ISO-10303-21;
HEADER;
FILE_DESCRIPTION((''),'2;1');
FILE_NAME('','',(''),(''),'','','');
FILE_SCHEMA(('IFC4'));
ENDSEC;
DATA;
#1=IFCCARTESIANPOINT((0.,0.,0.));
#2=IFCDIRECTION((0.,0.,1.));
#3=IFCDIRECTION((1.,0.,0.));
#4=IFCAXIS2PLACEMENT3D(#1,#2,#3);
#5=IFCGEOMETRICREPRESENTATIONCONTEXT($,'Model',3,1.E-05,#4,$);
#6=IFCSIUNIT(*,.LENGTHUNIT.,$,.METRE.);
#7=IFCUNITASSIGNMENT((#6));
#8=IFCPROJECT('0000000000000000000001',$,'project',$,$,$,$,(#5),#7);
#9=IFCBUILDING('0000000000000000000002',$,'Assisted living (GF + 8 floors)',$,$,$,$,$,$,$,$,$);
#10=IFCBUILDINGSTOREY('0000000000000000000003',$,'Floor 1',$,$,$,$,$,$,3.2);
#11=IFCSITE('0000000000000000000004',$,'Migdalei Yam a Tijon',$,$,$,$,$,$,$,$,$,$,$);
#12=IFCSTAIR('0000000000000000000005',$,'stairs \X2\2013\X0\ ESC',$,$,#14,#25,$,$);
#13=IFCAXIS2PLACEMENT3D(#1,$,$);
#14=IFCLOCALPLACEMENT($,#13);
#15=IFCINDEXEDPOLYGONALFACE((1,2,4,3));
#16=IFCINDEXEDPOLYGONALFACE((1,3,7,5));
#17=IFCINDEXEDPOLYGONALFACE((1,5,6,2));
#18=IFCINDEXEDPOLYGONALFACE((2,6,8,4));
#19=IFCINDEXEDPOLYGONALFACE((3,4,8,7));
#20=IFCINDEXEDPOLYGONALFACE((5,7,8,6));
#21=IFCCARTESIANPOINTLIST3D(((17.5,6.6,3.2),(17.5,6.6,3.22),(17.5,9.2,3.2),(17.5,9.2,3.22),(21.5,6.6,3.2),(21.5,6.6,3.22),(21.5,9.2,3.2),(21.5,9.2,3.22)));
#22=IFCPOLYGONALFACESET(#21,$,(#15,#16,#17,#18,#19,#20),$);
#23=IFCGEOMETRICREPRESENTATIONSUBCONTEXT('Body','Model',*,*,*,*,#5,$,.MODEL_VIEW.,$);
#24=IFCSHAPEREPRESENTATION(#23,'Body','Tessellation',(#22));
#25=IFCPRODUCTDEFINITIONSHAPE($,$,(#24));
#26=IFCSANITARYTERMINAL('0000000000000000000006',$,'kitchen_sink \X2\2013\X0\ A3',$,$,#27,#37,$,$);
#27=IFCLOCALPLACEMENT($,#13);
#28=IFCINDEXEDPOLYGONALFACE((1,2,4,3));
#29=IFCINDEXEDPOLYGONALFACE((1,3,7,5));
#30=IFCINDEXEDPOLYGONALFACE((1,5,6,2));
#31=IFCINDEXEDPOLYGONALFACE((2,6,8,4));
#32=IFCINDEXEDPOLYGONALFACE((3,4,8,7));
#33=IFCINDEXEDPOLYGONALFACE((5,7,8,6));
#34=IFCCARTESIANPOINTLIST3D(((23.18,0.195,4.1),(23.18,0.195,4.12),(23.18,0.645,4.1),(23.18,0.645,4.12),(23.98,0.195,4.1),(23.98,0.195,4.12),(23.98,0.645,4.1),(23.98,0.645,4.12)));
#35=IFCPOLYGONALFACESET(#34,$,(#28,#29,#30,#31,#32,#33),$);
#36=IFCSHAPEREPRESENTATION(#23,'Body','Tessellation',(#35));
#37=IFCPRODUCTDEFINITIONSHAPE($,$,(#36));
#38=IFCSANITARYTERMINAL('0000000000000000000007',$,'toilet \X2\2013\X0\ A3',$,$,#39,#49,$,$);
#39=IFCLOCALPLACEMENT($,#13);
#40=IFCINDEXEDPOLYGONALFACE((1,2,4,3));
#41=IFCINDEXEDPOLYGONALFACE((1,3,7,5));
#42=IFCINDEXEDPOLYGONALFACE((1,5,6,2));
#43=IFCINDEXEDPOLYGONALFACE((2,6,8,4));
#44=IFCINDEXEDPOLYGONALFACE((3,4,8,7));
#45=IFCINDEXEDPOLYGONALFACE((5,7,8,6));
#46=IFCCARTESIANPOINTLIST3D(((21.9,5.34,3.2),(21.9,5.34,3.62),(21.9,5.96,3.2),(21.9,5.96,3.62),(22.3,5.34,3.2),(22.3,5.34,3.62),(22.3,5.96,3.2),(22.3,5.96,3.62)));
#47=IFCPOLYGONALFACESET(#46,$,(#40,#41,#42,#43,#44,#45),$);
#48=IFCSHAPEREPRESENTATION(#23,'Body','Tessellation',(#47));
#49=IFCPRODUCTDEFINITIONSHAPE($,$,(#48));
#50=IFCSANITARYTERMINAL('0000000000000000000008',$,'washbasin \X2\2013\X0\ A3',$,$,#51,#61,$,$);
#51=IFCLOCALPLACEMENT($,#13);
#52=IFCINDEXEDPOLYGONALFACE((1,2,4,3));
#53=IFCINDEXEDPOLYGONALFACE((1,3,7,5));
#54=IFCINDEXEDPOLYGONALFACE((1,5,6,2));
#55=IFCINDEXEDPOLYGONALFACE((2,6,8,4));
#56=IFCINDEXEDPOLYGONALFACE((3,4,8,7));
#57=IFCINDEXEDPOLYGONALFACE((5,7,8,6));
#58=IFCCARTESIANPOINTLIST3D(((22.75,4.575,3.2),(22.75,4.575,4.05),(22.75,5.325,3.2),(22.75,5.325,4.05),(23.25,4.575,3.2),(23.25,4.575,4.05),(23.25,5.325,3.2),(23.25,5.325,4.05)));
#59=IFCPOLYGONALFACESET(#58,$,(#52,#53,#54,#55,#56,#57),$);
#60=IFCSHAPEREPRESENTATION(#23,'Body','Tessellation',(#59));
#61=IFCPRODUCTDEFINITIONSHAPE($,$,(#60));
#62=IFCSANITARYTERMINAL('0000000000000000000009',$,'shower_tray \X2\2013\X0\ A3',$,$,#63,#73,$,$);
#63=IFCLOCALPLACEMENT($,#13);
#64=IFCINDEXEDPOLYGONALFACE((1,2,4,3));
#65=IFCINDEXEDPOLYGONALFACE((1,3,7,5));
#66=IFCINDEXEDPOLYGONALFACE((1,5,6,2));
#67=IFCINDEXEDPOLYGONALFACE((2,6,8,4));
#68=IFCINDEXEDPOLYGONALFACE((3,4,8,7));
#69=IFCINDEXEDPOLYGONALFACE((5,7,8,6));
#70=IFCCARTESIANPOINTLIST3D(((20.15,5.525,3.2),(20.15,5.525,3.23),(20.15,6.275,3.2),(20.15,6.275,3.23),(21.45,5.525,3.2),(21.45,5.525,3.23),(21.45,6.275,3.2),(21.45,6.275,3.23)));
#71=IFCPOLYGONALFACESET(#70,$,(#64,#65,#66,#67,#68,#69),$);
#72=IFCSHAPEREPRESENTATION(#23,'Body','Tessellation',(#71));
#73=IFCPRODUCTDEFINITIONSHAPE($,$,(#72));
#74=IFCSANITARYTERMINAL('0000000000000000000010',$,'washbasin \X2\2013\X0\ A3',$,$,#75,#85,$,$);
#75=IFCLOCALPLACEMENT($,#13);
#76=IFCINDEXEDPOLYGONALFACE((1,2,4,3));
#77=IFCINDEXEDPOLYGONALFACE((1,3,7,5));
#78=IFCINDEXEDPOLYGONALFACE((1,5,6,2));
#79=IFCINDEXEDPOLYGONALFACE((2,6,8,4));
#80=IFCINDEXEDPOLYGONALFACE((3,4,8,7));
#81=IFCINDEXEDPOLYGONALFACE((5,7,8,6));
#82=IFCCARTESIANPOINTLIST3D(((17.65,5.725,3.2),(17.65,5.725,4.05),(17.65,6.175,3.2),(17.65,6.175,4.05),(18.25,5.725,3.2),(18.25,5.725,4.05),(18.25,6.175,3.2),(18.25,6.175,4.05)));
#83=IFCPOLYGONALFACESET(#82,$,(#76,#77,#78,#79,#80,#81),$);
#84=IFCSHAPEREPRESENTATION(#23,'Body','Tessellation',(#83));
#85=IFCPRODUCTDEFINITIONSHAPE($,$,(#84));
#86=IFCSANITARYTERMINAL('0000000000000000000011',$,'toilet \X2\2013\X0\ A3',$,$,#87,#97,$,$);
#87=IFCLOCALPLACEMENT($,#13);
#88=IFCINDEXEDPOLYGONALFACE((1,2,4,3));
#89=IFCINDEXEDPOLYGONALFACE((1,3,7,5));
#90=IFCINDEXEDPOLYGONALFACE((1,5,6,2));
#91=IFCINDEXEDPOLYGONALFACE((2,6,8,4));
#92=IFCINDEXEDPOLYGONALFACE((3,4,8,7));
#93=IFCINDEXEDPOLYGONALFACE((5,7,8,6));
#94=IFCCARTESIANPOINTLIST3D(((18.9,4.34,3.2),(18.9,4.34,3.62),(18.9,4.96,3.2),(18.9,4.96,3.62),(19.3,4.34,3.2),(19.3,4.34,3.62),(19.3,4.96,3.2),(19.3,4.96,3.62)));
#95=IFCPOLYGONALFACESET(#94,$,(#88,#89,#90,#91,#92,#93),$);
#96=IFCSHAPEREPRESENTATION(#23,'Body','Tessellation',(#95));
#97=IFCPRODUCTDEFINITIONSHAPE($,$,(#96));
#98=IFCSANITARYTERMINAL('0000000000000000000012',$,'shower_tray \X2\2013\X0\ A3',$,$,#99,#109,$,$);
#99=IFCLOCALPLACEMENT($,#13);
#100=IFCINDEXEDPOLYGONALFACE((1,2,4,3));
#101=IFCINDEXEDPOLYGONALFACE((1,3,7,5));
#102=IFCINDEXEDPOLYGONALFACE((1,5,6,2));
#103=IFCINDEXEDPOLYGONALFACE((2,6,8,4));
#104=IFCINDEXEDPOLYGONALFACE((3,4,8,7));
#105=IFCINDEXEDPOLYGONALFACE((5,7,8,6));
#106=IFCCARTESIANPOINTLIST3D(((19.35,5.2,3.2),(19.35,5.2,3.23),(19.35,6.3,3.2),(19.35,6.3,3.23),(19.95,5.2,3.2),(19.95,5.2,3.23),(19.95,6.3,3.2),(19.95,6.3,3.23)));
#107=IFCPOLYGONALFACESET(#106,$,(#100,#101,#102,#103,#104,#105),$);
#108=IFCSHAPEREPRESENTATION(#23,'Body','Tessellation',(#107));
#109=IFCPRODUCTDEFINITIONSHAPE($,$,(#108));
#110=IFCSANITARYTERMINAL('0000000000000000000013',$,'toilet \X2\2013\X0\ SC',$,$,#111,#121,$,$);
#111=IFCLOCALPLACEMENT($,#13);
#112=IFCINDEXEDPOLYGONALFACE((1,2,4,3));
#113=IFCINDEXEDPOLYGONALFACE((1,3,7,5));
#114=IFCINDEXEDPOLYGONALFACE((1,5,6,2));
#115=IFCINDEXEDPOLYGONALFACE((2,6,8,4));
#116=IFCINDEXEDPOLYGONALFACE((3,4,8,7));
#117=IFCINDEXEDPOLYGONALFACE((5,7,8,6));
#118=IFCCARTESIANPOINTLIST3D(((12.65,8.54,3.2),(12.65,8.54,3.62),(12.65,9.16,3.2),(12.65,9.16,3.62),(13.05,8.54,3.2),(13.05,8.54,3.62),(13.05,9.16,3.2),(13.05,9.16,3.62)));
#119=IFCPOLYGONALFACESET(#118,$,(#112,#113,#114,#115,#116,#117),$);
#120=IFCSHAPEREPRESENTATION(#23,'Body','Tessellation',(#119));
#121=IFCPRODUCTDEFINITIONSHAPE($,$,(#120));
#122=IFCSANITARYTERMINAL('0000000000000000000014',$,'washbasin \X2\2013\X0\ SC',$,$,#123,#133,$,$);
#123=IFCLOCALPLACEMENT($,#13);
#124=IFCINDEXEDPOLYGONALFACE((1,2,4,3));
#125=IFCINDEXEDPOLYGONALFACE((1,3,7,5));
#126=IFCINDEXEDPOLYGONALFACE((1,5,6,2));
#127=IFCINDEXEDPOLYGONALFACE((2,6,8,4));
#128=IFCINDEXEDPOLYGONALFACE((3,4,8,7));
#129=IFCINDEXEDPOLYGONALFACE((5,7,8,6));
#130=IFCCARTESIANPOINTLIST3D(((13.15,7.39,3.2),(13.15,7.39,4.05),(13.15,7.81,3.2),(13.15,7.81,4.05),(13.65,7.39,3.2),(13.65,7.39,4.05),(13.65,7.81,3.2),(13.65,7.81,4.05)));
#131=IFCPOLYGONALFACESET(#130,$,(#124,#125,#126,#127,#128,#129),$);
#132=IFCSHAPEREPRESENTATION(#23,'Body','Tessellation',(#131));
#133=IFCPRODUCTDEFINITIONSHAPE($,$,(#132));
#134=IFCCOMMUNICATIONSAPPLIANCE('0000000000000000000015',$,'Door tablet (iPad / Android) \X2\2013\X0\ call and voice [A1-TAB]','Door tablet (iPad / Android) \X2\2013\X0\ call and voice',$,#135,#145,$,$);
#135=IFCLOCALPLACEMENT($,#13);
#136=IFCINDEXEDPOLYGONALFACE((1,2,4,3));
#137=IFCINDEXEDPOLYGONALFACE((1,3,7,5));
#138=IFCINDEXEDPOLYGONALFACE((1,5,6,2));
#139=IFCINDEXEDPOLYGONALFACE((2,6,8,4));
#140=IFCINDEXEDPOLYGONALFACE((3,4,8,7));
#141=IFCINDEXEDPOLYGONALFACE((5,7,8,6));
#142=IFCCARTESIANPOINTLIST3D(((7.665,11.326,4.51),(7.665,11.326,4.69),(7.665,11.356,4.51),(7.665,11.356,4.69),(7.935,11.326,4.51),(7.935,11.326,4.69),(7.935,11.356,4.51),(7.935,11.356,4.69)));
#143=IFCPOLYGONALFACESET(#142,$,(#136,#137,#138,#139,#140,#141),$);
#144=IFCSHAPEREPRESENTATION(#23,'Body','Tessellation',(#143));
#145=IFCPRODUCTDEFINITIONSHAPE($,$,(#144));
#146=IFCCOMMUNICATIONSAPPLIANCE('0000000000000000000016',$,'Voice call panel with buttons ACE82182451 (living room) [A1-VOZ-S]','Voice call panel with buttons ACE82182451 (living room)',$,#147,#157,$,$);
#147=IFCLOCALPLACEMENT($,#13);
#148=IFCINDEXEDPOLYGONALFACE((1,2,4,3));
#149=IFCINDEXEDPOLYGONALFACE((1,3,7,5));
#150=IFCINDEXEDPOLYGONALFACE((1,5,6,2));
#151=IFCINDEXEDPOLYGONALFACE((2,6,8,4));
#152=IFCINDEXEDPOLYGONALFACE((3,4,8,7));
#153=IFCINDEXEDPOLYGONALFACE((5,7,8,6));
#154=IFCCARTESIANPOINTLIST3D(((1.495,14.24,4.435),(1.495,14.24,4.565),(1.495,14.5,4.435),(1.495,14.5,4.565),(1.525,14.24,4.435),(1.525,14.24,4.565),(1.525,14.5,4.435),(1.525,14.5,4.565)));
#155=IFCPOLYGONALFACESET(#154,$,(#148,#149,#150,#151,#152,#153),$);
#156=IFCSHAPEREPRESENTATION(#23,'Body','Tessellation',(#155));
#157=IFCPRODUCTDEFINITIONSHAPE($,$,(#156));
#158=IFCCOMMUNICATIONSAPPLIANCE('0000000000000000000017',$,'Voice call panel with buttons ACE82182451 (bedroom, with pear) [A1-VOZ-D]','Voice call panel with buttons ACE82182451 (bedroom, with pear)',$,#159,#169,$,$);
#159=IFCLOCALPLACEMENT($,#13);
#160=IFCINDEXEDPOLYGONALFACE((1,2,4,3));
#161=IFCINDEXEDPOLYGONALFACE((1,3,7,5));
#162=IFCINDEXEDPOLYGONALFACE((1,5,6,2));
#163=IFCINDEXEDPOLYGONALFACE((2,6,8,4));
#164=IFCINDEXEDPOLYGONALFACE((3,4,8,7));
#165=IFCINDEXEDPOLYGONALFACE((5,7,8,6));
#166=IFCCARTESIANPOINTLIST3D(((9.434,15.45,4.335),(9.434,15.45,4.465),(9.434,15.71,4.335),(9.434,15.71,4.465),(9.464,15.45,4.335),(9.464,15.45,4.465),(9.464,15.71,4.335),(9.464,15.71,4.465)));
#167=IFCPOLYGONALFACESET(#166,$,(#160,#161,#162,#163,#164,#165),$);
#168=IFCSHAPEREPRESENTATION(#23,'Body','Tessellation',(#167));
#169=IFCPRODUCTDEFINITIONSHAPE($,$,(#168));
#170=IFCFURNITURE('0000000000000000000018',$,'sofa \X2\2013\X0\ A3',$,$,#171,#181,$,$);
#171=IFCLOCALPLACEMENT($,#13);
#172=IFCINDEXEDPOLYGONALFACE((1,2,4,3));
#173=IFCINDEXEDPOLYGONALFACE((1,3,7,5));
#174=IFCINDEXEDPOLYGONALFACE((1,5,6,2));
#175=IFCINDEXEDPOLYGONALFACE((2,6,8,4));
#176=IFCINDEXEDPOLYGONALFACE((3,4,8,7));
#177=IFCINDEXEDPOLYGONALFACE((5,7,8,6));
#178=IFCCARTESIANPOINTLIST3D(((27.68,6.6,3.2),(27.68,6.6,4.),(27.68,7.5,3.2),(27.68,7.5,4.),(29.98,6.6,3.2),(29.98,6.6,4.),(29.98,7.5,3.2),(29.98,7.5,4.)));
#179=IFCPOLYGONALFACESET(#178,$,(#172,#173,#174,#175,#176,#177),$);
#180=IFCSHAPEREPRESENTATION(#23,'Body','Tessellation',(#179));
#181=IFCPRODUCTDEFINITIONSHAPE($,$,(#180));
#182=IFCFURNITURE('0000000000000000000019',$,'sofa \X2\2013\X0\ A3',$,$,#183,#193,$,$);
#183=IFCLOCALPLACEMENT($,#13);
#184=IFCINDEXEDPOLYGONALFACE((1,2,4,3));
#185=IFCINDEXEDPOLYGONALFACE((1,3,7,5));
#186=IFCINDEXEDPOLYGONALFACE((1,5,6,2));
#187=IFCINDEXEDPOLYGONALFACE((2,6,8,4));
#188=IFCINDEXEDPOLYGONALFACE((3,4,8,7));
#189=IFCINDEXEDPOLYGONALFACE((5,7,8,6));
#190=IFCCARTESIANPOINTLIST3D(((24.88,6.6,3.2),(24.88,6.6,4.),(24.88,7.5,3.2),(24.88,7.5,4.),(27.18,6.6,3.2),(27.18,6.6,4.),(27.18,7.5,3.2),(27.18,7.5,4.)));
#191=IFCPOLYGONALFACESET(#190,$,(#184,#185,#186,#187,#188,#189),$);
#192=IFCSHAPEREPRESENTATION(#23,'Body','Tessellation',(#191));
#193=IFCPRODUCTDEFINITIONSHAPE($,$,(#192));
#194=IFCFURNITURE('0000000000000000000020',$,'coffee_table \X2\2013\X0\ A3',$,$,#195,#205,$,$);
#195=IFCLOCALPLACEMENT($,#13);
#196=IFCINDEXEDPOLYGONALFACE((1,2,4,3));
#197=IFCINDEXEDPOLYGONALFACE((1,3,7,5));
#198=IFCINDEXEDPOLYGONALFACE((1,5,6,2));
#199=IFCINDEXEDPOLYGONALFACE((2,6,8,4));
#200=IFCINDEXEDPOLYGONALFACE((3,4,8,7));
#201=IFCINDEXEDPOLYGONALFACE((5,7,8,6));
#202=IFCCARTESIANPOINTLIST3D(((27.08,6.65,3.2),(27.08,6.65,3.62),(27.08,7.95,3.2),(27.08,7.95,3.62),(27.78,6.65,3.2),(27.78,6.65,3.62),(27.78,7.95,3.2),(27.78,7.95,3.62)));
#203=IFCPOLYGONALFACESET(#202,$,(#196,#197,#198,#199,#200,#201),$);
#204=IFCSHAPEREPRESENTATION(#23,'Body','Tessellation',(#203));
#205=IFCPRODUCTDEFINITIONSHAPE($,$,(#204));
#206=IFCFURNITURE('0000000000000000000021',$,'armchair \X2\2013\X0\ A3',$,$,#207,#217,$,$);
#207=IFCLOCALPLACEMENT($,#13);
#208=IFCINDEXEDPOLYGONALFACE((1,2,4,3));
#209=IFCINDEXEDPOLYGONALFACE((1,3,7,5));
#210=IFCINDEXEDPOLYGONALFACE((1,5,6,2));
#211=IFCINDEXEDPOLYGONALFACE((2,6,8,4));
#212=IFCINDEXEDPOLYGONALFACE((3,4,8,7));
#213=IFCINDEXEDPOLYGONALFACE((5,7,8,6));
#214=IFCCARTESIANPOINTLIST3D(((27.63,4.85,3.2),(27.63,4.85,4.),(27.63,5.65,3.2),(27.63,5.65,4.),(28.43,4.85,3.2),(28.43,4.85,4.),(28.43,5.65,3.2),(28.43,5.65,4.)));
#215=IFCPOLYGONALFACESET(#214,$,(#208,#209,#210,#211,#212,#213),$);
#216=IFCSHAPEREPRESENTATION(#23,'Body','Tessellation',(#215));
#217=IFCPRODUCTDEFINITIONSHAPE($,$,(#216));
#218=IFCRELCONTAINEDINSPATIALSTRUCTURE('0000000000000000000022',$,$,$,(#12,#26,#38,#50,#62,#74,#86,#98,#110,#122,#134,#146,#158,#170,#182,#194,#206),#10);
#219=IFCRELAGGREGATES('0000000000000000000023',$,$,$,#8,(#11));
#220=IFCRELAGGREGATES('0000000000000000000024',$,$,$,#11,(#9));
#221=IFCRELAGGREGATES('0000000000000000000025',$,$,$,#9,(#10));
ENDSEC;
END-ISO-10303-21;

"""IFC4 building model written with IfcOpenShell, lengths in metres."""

from ifc_helpers import new_model, si_unit, frame, origin_with_axes, context, subcontext, project, spatial, line, indexed_curve, outline, extrude, element, save


model = new_model("IFC4")

# Units and contexts
model_context = context("Model", 3, precision=1e-05, world=origin_with_axes())
body_context = subcontext(model_context, "Body", "Model", "MODEL_VIEW")
ifc_project = project(units=[si_unit("LENGTHUNIT", "METRE")], contexts=[model_context])

# Site, building, storey
site = spatial("IfcSite", under=ifc_project, Name="Migdalei Yam a Tijon")
building = spatial("IfcBuilding", under=site, Name="Assisted living (GF + 8 floors)")
storey = spatial("IfcBuildingStorey", under=building, Name="Floor 1", Elevation=3.2)

# Stair
element("IfcStair", 1, inside=storey, Name="stairs – ESC", context=body_context, shape_type="SweptSolid", body=[
    extrude(outline(indexed_curve([(0.0, 0.0), (4.0, 0.0), (4.0, 2.6), (0.0, 2.6)], segments=[line(1, 2, 3, 4, 1)])), frame((17.5, 6.6, 3.2), z_axis=(0.0, 0.0, 1.0), x_axis=(1.0, 0.0, 0.0)), (0.0, 0.0, 1.0), 0.02),
])

# Sanitary terminals
element("IfcSanitaryTerminal", 2, inside=storey, Name="kitchen_sink – A3", context=body_context, shape_type="SweptSolid", body=[
    extrude(outline(indexed_curve([(0.0, 0.0), (0.8, 0.0), (0.8, 0.45), (0.0, 0.45)], segments=[line(1, 2, 3, 4, 1)])), frame((23.18, 0.195, 4.1), z_axis=(0.0, 0.0, 1.0), x_axis=(1.0, 0.0, 0.0)), (0.0, 0.0, 1.0), 0.02),
])
element("IfcSanitaryTerminal", 3, inside=storey, Name="toilet – A3", context=body_context, shape_type="SweptSolid", body=[
    extrude(outline(indexed_curve([(0.0, 0.0), (0.4, 0.0), (0.4, 0.62), (0.0, 0.62)], segments=[line(1, 2, 3, 4, 1)])), frame((21.9, 5.34, 3.2), z_axis=(0.0, 0.0, 1.0), x_axis=(1.0, 0.0, 0.0)), (0.0, 0.0, 1.0), 0.42),
])
element("IfcSanitaryTerminal", 4, inside=storey, Name="washbasin – A3", context=body_context, shape_type="SweptSolid", body=[
    extrude(outline(indexed_curve([(0.0, 0.0), (0.5, 0.0), (0.5, 0.75), (0.0, 0.75)], segments=[line(1, 2, 3, 4, 1)])), frame((22.75, 4.575, 3.2), z_axis=(0.0, 0.0, 1.0), x_axis=(1.0, 0.0, 0.0)), (0.0, 0.0, 1.0), 0.85),
])
element("IfcSanitaryTerminal", 5, inside=storey, Name="shower_tray – A3", context=body_context, shape_type="SweptSolid", body=[
    extrude(outline(indexed_curve([(0.0, 0.0), (1.3, 0.0), (1.3, 0.75), (0.0, 0.75)], segments=[line(1, 2, 3, 4, 1)])), frame((20.15, 5.525, 3.2), z_axis=(0.0, 0.0, 1.0), x_axis=(1.0, 0.0, 0.0)), (0.0, 0.0, 1.0), 0.03),
])
element("IfcSanitaryTerminal", 6, inside=storey, Name="washbasin – A3", context=body_context, shape_type="SweptSolid", body=[
    extrude(outline(indexed_curve([(0.0, 0.0), (0.6, 0.0), (0.6, 0.45), (0.0, 0.45)], segments=[line(1, 2, 3, 4, 1)])), frame((17.65, 5.725, 3.2), z_axis=(0.0, 0.0, 1.0), x_axis=(1.0, 0.0, 0.0)), (0.0, 0.0, 1.0), 0.85),
])
element("IfcSanitaryTerminal", 7, inside=storey, Name="toilet – A3", context=body_context, shape_type="SweptSolid", body=[
    extrude(outline(indexed_curve([(0.0, 0.0), (0.4, 0.0), (0.4, 0.62), (0.0, 0.62)], segments=[line(1, 2, 3, 4, 1)])), frame((18.9, 4.34, 3.2), z_axis=(0.0, 0.0, 1.0), x_axis=(1.0, 0.0, 0.0)), (0.0, 0.0, 1.0), 0.42),
])
element("IfcSanitaryTerminal", 8, inside=storey, Name="shower_tray – A3", context=body_context, shape_type="SweptSolid", body=[
    extrude(outline(indexed_curve([(0.0, 0.0), (0.6, 0.0), (0.6, 1.1), (0.0, 1.1)], segments=[line(1, 2, 3, 4, 1)])), frame((19.35, 5.2, 3.2), z_axis=(0.0, 0.0, 1.0), x_axis=(1.0, 0.0, 0.0)), (0.0, 0.0, 1.0), 0.03),
])
element("IfcSanitaryTerminal", 9, inside=storey, Name="toilet – SC", context=body_context, shape_type="SweptSolid", body=[
    extrude(outline(indexed_curve([(0.0, 0.0), (0.4, 0.0), (0.4, 0.62), (0.0, 0.62)], segments=[line(1, 2, 3, 4, 1)])), frame((12.65, 8.54, 3.2), z_axis=(0.0, 0.0, 1.0), x_axis=(1.0, 0.0, 0.0)), (0.0, 0.0, 1.0), 0.42),
])
element("IfcSanitaryTerminal", 10, inside=storey, Name="washbasin – SC", context=body_context, shape_type="SweptSolid", body=[
    extrude(outline(indexed_curve([(0.0, 0.0), (0.5, 0.0), (0.5, 0.42), (0.0, 0.42)], segments=[line(1, 2, 3, 4, 1)])), frame((13.15, 7.39, 3.2), z_axis=(0.0, 0.0, 1.0), x_axis=(1.0, 0.0, 0.0)), (0.0, 0.0, 1.0), 0.85),
])

# Communications appliances
element("IfcCommunicationsAppliance", 11, inside=storey, Name="Door tablet (iPad / Android) – call and voice [A1-TAB]", Description="Door tablet (iPad / Android) – call and voice", context=body_context, shape_type="SweptSolid", body=[
    extrude(outline(indexed_curve([(0.0, 0.0), (0.27, 0.0), (0.27, 0.03), (0.0, 0.03)], segments=[line(1, 2, 3, 4, 1)])), frame((7.665, 11.326, 4.51), z_axis=(0.0, 0.0, 1.0), x_axis=(1.0, 0.0, 0.0)), (0.0, 0.0, 1.0), 0.18),
])
element("IfcCommunicationsAppliance", 12, inside=storey, Name="Voice call panel with buttons ACE82182451 (living room) [A1-VOZ-S]", Description="Voice call panel with buttons ACE82182451 (living room)", context=body_context, shape_type="SweptSolid", body=[
    extrude(outline(indexed_curve([(0.0, 0.0), (0.03, 0.0), (0.03, 0.26), (0.0, 0.26)], segments=[line(1, 2, 3, 4, 1)])), frame((1.495, 14.24, 4.435), z_axis=(0.0, 0.0, 1.0), x_axis=(1.0, 0.0, 0.0)), (0.0, 0.0, 1.0), 0.13),
])
element("IfcCommunicationsAppliance", 13, inside=storey, Name="Voice call panel with buttons ACE82182451 (bedroom, with pear) [A1-VOZ-D]", Description="Voice call panel with buttons ACE82182451 (bedroom, with pear)", context=body_context, shape_type="SweptSolid", body=[
    extrude(outline(indexed_curve([(0.0, 0.0), (0.03, 0.0), (0.03, 0.26), (0.0, 0.26)], segments=[line(1, 2, 3, 4, 1)])), frame((9.434, 15.45, 4.335), z_axis=(0.0, 0.0, 1.0), x_axis=(1.0, 0.0, 0.0)), (0.0, 0.0, 1.0), 0.13),
])

# Furniture
element("IfcFurniture", 14, inside=storey, Name="sofa – A3", context=body_context, shape_type="SweptSolid", body=[
    extrude(outline(indexed_curve([(0.0, 0.0), (2.3, 0.0), (2.3, 0.9), (0.0, 0.9)], segments=[line(1, 2, 3, 4, 1)])), frame((27.68, 6.6, 3.2), z_axis=(0.0, 0.0, 1.0), x_axis=(1.0, 0.0, 0.0)), (0.0, 0.0, 1.0), 0.8),
])
element("IfcFurniture", 15, inside=storey, Name="sofa – A3", context=body_context, shape_type="SweptSolid", body=[
    extrude(outline(indexed_curve([(0.0, 0.0), (2.3, 0.0), (2.3, 0.9), (0.0, 0.9)], segments=[line(1, 2, 3, 4, 1)])), frame((24.88, 6.6, 3.2), z_axis=(0.0, 0.0, 1.0), x_axis=(1.0, 0.0, 0.0)), (0.0, 0.0, 1.0), 0.8),
])
element("IfcFurniture", 16, inside=storey, Name="coffee_table – A3", context=body_context, shape_type="SweptSolid", body=[
    extrude(outline(indexed_curve([(0.0, 0.0), (0.7, 0.0), (0.7, 1.3), (0.0, 1.3)], segments=[line(1, 2, 3, 4, 1)])), frame((27.08, 6.65, 3.2), z_axis=(0.0, 0.0, 1.0), x_axis=(1.0, 0.0, 0.0)), (0.0, 0.0, 1.0), 0.42),
])
element("IfcFurniture", 17, inside=storey, Name="armchair – A3", context=body_context, shape_type="SweptSolid", body=[
    extrude(outline(indexed_curve([(0.0, 0.0), (0.8, 0.0), (0.8, 0.8), (0.0, 0.8)], segments=[line(1, 2, 3, 4, 1)])), frame((27.63, 4.85, 3.2), z_axis=(0.0, 0.0, 1.0), x_axis=(1.0, 0.0, 0.0)), (0.0, 0.0, 1.0), 0.8),
])

save(model, "model.ifc")
